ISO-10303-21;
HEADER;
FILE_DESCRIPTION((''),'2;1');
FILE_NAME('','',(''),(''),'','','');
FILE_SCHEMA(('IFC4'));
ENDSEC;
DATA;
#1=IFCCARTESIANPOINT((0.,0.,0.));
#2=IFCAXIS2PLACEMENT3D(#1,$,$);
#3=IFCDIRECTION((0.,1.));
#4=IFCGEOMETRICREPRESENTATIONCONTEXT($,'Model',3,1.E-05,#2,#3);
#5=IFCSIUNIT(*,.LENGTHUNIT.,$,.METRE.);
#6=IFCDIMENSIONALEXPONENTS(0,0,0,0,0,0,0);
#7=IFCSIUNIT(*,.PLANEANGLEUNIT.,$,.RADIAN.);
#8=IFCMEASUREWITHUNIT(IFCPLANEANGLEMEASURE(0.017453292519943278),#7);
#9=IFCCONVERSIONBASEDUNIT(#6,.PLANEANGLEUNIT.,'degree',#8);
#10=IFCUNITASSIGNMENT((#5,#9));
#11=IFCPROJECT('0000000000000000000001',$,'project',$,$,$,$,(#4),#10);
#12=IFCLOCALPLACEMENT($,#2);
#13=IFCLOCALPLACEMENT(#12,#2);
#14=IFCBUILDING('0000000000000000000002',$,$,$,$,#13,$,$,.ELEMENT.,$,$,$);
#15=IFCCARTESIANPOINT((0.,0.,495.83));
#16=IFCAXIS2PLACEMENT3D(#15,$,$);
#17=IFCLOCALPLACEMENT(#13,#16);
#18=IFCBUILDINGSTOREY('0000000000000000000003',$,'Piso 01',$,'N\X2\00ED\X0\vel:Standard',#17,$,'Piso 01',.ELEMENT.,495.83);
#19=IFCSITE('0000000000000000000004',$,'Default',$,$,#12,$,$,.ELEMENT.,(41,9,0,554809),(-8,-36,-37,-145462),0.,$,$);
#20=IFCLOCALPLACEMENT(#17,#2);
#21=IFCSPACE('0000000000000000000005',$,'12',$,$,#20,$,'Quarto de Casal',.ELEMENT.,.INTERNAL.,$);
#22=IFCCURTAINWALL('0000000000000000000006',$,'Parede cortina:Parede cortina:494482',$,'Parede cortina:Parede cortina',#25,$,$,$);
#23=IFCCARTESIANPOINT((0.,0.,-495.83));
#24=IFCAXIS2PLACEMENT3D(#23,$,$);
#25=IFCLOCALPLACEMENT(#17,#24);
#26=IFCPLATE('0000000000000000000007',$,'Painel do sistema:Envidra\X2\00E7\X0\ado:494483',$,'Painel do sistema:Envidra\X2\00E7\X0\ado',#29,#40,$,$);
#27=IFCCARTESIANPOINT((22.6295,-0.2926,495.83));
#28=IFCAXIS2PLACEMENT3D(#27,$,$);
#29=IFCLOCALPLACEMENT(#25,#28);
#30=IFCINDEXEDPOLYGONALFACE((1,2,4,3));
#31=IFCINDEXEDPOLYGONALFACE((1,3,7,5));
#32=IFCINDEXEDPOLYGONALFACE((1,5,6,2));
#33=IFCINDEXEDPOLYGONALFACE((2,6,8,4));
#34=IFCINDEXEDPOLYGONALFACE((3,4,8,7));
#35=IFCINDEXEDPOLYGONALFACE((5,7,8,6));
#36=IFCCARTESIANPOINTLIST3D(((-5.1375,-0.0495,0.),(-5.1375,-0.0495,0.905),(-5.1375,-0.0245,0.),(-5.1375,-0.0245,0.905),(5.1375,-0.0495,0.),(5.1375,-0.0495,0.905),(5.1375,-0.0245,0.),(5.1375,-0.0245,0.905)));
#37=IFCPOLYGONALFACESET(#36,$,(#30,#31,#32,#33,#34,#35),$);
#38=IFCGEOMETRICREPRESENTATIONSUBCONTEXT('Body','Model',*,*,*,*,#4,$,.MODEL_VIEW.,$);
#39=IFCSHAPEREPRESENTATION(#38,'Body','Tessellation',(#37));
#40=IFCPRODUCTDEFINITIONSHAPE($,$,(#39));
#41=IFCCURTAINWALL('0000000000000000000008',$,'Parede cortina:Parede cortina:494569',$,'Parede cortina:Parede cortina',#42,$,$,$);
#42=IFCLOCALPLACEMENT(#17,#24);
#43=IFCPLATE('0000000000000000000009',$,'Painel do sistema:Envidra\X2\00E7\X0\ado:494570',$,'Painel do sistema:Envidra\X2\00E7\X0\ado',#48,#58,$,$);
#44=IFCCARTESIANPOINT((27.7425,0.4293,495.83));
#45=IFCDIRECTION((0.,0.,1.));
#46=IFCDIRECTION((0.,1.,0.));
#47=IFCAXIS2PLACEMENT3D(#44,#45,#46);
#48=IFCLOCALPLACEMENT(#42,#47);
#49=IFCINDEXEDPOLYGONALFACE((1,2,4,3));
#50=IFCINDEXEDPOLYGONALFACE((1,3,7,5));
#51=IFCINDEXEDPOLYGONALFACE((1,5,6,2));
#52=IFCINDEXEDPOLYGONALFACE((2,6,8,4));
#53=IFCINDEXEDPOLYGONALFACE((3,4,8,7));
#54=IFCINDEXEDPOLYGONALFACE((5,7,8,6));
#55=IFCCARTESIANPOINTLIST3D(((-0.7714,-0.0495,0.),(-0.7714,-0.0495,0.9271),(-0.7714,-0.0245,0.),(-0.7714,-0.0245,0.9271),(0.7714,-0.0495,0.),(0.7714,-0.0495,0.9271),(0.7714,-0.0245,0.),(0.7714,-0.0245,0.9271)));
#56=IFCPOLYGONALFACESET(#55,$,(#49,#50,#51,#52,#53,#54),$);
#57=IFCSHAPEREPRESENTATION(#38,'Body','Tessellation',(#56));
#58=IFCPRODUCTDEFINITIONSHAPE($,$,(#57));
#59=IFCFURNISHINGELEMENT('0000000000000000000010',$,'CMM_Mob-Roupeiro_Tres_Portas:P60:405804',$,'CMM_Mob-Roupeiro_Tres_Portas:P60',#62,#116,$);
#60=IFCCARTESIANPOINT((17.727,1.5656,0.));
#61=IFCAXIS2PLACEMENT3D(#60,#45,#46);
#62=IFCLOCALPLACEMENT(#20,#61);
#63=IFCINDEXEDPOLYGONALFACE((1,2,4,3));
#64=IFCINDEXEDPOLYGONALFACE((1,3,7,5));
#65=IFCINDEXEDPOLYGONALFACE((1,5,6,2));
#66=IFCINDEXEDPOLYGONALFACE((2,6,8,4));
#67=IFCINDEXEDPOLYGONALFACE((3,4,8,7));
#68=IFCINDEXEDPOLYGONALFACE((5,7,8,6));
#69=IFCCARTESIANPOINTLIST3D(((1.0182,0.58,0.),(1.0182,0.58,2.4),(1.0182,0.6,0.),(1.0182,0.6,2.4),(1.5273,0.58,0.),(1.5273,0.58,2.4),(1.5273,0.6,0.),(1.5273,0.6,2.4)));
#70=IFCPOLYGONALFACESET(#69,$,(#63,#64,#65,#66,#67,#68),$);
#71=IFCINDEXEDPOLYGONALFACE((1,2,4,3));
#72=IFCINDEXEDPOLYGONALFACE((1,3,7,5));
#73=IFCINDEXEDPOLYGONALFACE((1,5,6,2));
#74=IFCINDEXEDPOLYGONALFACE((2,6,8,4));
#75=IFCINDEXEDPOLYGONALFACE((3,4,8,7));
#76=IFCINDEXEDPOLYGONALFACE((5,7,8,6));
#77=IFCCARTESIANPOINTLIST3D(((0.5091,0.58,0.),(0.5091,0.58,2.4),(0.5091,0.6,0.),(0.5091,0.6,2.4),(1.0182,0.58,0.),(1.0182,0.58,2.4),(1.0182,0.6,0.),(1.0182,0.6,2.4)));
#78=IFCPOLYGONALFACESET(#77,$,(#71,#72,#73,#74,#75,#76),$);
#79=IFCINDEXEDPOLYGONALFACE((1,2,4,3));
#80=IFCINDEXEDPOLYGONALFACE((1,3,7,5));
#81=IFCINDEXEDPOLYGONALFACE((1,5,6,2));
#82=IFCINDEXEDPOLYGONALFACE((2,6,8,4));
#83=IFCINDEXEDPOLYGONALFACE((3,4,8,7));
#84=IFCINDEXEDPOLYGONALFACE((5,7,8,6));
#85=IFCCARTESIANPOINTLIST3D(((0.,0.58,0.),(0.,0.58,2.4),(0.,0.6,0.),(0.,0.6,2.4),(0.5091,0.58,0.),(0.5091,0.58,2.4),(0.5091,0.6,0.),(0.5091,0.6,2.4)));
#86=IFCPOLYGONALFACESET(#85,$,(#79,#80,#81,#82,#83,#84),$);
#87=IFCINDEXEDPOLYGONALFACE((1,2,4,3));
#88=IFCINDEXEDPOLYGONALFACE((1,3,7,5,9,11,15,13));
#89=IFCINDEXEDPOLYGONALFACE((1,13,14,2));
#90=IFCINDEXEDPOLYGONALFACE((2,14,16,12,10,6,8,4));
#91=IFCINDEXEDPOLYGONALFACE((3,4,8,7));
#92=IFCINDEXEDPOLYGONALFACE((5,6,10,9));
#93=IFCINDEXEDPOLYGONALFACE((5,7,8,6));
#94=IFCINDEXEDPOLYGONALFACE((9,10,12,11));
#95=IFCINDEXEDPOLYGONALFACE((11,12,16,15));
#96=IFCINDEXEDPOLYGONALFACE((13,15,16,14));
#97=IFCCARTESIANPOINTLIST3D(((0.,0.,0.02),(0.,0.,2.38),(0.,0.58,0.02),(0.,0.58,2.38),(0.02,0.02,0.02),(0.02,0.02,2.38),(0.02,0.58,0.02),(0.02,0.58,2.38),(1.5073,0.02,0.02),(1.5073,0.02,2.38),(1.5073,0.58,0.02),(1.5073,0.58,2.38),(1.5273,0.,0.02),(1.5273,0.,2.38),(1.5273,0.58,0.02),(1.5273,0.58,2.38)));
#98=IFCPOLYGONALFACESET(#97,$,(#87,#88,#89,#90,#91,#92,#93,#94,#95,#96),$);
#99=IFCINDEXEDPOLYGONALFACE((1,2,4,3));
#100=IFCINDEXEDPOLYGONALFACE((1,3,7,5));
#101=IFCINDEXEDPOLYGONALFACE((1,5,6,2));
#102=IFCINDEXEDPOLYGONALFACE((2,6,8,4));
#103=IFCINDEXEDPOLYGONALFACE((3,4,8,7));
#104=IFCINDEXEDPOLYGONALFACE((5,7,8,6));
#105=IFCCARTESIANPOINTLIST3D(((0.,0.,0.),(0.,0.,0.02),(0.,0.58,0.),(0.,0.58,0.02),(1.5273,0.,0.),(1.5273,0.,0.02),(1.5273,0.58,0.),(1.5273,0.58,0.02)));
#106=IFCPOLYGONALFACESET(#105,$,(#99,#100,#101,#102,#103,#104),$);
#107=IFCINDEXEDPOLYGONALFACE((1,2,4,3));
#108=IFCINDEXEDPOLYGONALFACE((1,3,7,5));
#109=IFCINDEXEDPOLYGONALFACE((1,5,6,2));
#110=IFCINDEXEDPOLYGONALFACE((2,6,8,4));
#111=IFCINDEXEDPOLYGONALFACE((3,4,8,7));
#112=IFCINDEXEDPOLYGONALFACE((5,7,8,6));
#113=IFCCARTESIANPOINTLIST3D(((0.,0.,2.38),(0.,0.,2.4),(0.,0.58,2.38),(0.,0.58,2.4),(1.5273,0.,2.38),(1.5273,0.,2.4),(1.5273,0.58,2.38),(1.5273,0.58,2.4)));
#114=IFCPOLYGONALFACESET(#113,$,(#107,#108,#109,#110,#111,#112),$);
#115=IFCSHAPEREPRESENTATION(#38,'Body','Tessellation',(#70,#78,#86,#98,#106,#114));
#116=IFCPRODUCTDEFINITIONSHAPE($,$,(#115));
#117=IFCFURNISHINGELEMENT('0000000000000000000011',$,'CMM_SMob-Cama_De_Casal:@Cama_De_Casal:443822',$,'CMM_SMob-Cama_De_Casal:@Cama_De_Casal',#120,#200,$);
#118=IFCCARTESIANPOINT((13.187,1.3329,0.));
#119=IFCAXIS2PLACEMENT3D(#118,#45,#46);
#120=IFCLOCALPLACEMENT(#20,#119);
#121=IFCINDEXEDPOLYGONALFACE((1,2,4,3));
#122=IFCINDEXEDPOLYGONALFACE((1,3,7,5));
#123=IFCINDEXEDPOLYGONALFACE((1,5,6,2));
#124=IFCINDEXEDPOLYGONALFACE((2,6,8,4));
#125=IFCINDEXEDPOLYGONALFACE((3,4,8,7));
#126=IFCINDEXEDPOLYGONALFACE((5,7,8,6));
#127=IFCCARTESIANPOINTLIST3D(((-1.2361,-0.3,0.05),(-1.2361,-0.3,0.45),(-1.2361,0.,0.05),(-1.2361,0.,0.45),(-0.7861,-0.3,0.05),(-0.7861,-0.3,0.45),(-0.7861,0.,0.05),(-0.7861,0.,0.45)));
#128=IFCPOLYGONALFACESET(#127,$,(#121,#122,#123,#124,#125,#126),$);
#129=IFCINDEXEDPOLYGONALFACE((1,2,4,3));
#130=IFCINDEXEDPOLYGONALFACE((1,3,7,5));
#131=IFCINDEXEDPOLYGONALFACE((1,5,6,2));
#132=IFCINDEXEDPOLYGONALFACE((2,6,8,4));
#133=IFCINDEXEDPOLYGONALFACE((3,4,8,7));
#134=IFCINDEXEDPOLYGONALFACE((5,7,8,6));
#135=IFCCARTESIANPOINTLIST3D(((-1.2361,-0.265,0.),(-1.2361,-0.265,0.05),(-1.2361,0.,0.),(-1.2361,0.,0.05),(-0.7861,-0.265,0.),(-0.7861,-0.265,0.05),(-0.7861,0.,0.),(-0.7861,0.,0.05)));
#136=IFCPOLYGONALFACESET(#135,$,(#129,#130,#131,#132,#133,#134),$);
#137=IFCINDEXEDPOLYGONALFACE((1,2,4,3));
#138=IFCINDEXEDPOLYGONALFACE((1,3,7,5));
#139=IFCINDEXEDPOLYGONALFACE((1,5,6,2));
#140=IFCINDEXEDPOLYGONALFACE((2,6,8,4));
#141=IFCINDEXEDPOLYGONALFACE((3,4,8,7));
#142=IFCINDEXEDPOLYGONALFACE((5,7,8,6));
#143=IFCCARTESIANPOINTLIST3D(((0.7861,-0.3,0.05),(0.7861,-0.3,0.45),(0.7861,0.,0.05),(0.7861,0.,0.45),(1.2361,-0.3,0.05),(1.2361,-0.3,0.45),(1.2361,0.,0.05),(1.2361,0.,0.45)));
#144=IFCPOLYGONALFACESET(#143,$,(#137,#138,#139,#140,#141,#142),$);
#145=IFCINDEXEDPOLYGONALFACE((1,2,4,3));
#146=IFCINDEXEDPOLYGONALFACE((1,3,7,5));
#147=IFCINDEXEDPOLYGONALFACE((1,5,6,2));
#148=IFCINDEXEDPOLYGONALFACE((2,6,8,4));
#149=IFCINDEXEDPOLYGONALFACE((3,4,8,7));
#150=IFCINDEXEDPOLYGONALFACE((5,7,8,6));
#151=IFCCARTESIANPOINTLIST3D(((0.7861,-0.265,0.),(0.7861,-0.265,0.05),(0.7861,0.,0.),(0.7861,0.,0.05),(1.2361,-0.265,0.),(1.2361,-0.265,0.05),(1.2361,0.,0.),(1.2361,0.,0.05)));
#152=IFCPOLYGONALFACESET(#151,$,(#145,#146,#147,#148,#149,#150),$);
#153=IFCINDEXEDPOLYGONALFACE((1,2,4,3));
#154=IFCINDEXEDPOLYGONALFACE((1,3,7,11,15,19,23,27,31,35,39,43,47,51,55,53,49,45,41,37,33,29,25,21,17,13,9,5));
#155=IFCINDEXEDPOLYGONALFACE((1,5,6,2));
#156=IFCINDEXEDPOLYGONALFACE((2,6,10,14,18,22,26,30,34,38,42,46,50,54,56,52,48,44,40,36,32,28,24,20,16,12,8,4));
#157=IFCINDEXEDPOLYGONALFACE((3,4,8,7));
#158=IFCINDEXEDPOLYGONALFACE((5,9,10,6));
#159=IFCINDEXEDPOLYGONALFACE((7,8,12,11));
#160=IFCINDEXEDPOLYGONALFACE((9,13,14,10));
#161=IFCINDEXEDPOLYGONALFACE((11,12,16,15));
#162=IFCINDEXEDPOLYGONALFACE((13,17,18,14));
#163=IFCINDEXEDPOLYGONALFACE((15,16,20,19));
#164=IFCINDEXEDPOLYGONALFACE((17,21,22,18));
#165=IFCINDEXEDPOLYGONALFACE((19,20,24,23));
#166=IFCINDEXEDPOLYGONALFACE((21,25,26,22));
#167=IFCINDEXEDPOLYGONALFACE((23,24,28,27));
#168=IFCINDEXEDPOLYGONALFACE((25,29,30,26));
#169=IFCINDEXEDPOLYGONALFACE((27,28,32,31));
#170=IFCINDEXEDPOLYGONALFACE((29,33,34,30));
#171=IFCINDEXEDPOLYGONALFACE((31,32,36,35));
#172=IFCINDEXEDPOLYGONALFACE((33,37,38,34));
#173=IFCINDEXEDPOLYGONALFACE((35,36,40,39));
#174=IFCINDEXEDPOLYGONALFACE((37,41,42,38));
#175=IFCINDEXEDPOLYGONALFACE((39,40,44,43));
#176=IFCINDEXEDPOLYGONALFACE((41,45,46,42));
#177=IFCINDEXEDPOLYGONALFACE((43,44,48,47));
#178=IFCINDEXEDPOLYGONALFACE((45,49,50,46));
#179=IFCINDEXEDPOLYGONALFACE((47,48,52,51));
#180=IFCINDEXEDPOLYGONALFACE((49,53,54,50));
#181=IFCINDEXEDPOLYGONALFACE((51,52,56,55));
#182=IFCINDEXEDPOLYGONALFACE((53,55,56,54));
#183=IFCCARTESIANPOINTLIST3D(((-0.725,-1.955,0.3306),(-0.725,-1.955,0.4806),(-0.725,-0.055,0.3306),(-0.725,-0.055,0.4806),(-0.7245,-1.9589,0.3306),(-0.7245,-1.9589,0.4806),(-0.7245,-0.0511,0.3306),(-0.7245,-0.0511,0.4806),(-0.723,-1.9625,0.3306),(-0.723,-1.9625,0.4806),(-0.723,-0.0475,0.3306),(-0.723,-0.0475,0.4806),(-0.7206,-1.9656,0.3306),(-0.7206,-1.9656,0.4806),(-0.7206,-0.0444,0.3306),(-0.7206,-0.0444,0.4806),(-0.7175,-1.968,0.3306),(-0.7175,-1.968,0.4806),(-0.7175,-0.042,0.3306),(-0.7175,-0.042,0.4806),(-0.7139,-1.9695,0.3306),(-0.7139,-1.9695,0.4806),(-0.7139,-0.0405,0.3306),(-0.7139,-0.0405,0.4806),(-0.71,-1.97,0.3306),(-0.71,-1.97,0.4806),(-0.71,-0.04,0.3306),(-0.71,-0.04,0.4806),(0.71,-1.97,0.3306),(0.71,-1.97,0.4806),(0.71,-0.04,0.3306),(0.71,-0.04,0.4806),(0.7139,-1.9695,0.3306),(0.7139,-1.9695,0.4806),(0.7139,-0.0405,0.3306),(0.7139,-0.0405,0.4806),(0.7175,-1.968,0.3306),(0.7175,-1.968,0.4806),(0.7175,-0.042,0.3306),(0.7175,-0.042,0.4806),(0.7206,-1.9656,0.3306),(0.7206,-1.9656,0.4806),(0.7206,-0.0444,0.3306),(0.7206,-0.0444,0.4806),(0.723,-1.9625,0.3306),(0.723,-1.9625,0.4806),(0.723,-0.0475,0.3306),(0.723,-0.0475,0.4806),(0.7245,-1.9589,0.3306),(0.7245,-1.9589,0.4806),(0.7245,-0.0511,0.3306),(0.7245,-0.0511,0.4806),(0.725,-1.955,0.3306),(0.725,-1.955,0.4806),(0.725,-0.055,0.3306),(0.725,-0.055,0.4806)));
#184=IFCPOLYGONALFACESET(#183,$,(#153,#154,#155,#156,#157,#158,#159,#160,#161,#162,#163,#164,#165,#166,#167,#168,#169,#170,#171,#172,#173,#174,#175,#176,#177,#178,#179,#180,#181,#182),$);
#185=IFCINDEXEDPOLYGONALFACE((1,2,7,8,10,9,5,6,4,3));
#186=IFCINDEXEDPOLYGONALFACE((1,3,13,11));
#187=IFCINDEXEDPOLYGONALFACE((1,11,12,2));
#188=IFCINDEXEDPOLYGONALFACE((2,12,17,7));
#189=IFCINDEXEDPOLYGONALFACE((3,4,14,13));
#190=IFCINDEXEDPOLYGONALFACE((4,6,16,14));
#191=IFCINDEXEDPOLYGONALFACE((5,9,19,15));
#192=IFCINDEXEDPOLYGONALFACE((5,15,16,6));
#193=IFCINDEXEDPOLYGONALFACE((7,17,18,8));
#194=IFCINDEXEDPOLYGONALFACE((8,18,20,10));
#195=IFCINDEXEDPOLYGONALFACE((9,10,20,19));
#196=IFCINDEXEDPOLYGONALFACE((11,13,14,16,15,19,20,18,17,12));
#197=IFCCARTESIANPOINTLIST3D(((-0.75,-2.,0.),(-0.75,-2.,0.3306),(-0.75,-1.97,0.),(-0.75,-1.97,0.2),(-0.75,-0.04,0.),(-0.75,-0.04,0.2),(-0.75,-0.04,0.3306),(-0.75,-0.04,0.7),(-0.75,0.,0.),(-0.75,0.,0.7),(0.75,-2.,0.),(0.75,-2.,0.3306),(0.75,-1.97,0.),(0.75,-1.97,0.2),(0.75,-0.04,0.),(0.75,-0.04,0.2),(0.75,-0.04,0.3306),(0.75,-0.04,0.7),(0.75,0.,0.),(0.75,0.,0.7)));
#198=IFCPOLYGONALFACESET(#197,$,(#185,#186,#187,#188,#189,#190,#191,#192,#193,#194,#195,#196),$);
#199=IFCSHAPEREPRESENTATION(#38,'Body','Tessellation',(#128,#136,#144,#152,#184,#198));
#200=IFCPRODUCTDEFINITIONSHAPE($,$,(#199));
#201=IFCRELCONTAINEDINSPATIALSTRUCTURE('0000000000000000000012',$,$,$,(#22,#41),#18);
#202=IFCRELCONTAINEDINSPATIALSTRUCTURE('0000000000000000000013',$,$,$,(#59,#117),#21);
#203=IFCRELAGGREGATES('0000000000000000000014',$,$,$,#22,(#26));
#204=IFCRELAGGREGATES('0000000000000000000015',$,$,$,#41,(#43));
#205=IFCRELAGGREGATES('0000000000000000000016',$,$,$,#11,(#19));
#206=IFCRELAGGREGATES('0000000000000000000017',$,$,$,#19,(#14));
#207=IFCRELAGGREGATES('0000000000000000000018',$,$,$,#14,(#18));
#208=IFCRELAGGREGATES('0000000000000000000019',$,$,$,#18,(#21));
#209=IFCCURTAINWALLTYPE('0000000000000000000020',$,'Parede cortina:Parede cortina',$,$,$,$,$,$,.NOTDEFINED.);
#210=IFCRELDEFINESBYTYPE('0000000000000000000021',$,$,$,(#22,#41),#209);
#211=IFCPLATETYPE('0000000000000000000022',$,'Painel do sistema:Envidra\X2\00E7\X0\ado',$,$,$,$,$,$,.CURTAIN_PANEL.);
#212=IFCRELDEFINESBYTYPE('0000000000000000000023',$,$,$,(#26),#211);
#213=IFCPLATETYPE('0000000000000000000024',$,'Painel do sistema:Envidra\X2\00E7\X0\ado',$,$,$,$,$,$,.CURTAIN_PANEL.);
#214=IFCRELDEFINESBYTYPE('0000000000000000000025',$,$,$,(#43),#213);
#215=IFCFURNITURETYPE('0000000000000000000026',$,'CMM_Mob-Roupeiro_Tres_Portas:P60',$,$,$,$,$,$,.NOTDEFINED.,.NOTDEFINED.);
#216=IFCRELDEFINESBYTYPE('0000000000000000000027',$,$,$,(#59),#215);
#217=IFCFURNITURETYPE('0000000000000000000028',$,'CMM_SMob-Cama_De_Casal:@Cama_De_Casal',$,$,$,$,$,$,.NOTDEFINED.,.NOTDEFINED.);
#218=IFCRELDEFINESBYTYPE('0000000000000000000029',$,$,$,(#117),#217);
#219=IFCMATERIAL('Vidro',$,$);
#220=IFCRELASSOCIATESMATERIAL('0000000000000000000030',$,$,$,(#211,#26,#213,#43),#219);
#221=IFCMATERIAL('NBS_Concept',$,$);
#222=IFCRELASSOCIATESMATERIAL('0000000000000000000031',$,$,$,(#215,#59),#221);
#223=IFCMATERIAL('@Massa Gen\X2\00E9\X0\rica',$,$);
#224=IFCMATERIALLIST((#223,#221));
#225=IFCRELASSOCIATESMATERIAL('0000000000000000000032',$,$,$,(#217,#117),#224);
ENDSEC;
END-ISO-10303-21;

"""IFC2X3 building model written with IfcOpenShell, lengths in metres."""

from ifc_helpers import new_model, entity, si_unit, converted_unit, direction, frame, frame_2d, origin, origin_2d_with_axis, place, context, subcontext, project, spatial, polyline, circle_curve, parameter, trimmed, segment, composite_curve, rectangle, outline, extrude, source, transform, mapped, material, material_list, type_object, type_shapes, element, aggregate, save


model = new_model("IFC2X3")

# Units and contexts
model_context = context("Model", 3, precision=1e-05, world=origin(), true_north=direction((0.0, 1.0)))
body_context = subcontext(model_context, "Body", "Model", "MODEL_VIEW")
ifc_project = project(units=[si_unit("LENGTHUNIT", "METRE"), converted_unit("PLANEANGLEUNIT", "degree", entity("IfcPlaneAngleMeasure", 0.017453292519943278), si_unit("PLANEANGLEUNIT", "RADIAN"), dimensions=[0, 0, 0, 0, 0, 0, 0])], contexts=[model_context])

# Site, building, storey
site_placement = place(None, origin())
site = spatial("IfcSite", under=ifc_project, at=site_placement, Name="Default", CompositionType="ELEMENT", RefLatitude=(41, 9, 0, 554809), RefLongitude=(-8, -36, -37, -145462), RefElevation=0.0)
building_placement = place(site_placement, origin())
building = spatial("IfcBuilding", under=site, at=building_placement, CompositionType="ELEMENT")
storey_placement = place(building_placement, frame((0.0, 0.0, 495.83)))
storey = spatial("IfcBuildingStorey", under=building, at=storey_placement, Name="Piso 01", ObjectType="Nível:Standard", LongName="Piso 01", CompositionType="ELEMENT", Elevation=495.83)

# Curtain walls, plates
curtain_wall_type = type_object("IfcCurtainWallType", Name="Parede cortina:Parede cortina", PredefinedType="NOTDEFINED")
curtain_wall_1_placement = place(storey_placement, frame((0.0, 0.0, -495.83)))
curtain_wall_1 = element("IfcCurtainWall", 1, at=curtain_wall_1_placement, inside=storey, type_object=curtain_wall_type, Name="Parede cortina:Parede cortina:494482", ObjectType="Parede cortina:Parede cortina")
ifc_material_1 = material(Name="Vidro")
plate_type_1 = type_object("IfcPlateType", Name="Painel do sistema:Envidraçado", PredefinedType="CURTAIN_PANEL", material=ifc_material_1)
shared_shape_1 = source(origin(), body_context, "Body", "SweptSolid", [
    extrude(rectangle(XDim=0.025, YDim=10.275, at=frame_2d((0.0, 0.0), x_axis=(1.0, 0.0))), frame((0.0, -0.037, 0.0), z_axis=(0.0, 0.0, 1.0), x_axis=(0.0, 1.0, 0.0)), (0.0, 0.0, 1.0), 0.905),
])
type_shapes(plate_type_1, [shared_shape_1])
plate_1_placement = place(curtain_wall_1_placement, frame((22.6295, -0.2926, 495.83)))
plate_1 = element("IfcPlate", 2, at=plate_1_placement, type_object=plate_type_1, material=ifc_material_1, Name="Painel do sistema:Envidraçado:494483", ObjectType="Painel do sistema:Envidraçado", context=body_context, shape_type="MappedRepresentation", body=[
    mapped(shared_shape_1, transform((0.0, 0.0, 0.0), scale=1.0)),
])
aggregate(curtain_wall_1, [plate_1])
curtain_wall_2_placement = place(storey_placement, frame((0.0, 0.0, -495.83)))
curtain_wall_2 = element("IfcCurtainWall", 3, at=curtain_wall_2_placement, inside=storey, type_object=curtain_wall_type, Name="Parede cortina:Parede cortina:494569", ObjectType="Parede cortina:Parede cortina")
plate_type_2 = type_object("IfcPlateType", Name="Painel do sistema:Envidraçado", PredefinedType="CURTAIN_PANEL", material=ifc_material_1)
shared_shape_2 = source(origin(), body_context, "Body", "SweptSolid", [
    extrude(rectangle(XDim=0.025, YDim=1.5427, at=frame_2d((0.0, 0.0), x_axis=(1.0, 0.0))), frame((0.0, -0.037, 0.0), z_axis=(0.0, 0.0, 1.0), x_axis=(0.0, 1.0, 0.0)), (0.0, 0.0, 1.0), 0.9271),
])
type_shapes(plate_type_2, [shared_shape_2])
plate_2_placement = place(curtain_wall_2_placement, frame((27.7425, 0.4293, 495.83), z_axis=(0.0, 0.0, 1.0), x_axis=(0.0, 1.0, 0.0)))
plate_2 = element("IfcPlate", 4, at=plate_2_placement, type_object=plate_type_2, material=ifc_material_1, Name="Painel do sistema:Envidraçado:494570", ObjectType="Painel do sistema:Envidraçado", context=body_context, shape_type="MappedRepresentation", body=[
    mapped(shared_shape_2, transform((0.0, 0.0, 0.0), scale=1.0)),
])
aggregate(curtain_wall_2, [plate_2])

# Shared definitions
space_1_placement = place(storey_placement, origin())
space_1 = spatial("IfcSpace", under=storey, at=space_1_placement, Name="12", LongName="Quarto de Casal", CompositionType="ELEMENT", InteriorOrExteriorSpace="INTERNAL")

# Furnishing element
ifc_material_2 = material(Name="NBS_Concept")
furniture_type_1 = type_object("IfcFurnitureType", Name="CMM_Mob-Roupeiro_Tres_Portas:P60", AssemblyPlace="NOTDEFINED", material=ifc_material_2)
shared_shape_3 = source(origin(), body_context, "Body", "SweptSolid", [
    extrude(rectangle(XDim=0.5091, YDim=0.02, at=frame_2d((0.0, 0.0), x_axis=(1.0, 0.0))), frame((1.2727, 0.59, 0.0), z_axis=(0.0, 0.0, 1.0), x_axis=(-1.0, 0.0, 0.0)), (0.0, 0.0, 1.0), 2.4),
    extrude(rectangle(XDim=0.5091, YDim=0.02, at=frame_2d((0.0, 0.0), x_axis=(1.0, 0.0))), frame((0.7636, 0.59, 0.0), z_axis=(0.0, 0.0, 1.0), x_axis=(-1.0, 0.0, 0.0)), (0.0, 0.0, 1.0), 2.4),
    extrude(rectangle(XDim=0.5091, YDim=0.02, at=frame_2d((0.0, 0.0), x_axis=(1.0, 0.0))), frame((0.2545, 0.59, 0.0), z_axis=(0.0, 0.0, 1.0), x_axis=(-1.0, 0.0, 0.0)), (0.0, 0.0, 1.0), 2.4),
    extrude(outline(polyline([(-0.7636, -0.295), (0.7636, -0.295), (0.7636, 0.285), (0.7436, 0.285), (0.7436, -0.275), (-0.7436, -0.275), (-0.7436, 0.285), (-0.7636, 0.285), (-0.7636, -0.295)])), frame((0.7636, 0.295, 0.02)), (0.0, 0.0, 1.0), 2.36),
    extrude(rectangle(XDim=1.5273, YDim=0.58, at=frame_2d((0.0, 0.0), x_axis=(1.0, 0.0))), frame((0.7636, 0.29, 0.0), z_axis=(0.0, 0.0, 1.0), x_axis=(-1.0, 0.0, 0.0)), (0.0, 0.0, 1.0), 0.02),
    extrude(rectangle(XDim=1.5273, YDim=0.58, at=frame_2d((0.0, 0.0), x_axis=(1.0, 0.0))), frame((0.7636, 0.29, 2.38), z_axis=(0.0, 0.0, 1.0), x_axis=(-1.0, 0.0, 0.0)), (0.0, 0.0, 1.0), 0.02),
])
type_shapes(furniture_type_1, [shared_shape_3])
furnishing_1_placement = place(space_1_placement, frame((17.727, 1.5656, 0.0), z_axis=(0.0, 0.0, 1.0), x_axis=(0.0, 1.0, 0.0)))
element("IfcFurnishingElement", 5, at=furnishing_1_placement, inside=space_1, type_object=furniture_type_1, material=ifc_material_2, Name="CMM_Mob-Roupeiro_Tres_Portas:P60:405804", ObjectType="CMM_Mob-Roupeiro_Tres_Portas:P60", context=body_context, shape_type="MappedRepresentation", body=[
    mapped(shared_shape_3, transform((0.0, 0.0, 0.0), scale=1.0)),
])

# Furnishing element
ifc_material_3 = material(Name="@Massa Genérica")
ifc_material_list = material_list([ifc_material_3, ifc_material_2])
furniture_type_2 = type_object("IfcFurnitureType", Name="CMM_SMob-Cama_De_Casal:@Cama_De_Casal", AssemblyPlace="NOTDEFINED", material=ifc_material_list)
shared_shape_4 = source(origin(), body_context, "Body", "SweptSolid", [
    extrude(rectangle(XDim=0.3, YDim=0.45, at=frame_2d((0.0, 0.0), x_axis=(1.0, 0.0))), frame((-1.0111, -0.15, 0.05), z_axis=(0.0, 0.0, 1.0), x_axis=(0.0, 1.0, 0.0)), (0.0, 0.0, 1.0), 0.4),
    extrude(rectangle(XDim=0.265, YDim=0.45, at=frame_2d((0.0, 0.0), x_axis=(1.0, 0.0))), frame((-1.0111, -0.1325, 0.0), z_axis=(0.0, 0.0, 1.0), x_axis=(0.0, -1.0, 0.0)), (0.0, 0.0, 1.0), 0.05),
    extrude(rectangle(XDim=0.45, YDim=0.3, at=origin_2d_with_axis()), frame((1.0111, -0.15, 0.05)), (0.0, 0.0, 1.0), 0.4),
    extrude(rectangle(XDim=0.45, YDim=0.265, at=origin_2d_with_axis()), frame((1.0111, -0.1325, 0.0), z_axis=(0.0, 0.0, 1.0), x_axis=(-1.0, 0.0, 0.0)), (0.0, 0.0, 1.0), 0.05),
    extrude(outline(composite_curve([segment(polyline([(-0.71, -0.965), (0.71, -0.965)]), True, "CONTINUOUS"), segment(trimmed(circle_curve(frame_2d((0.71, -0.95), x_axis=(-1.0, 0.0)), 0.015), [parameter(90.0)], [parameter(180.0)], True, "PARAMETER"), True, "CONTINUOUS"), segment(polyline([(0.725, -0.95), (0.725, 0.95)]), True, "CONTINUOUS"), segment(trimmed(circle_curve(frame_2d((0.71, 0.95), x_axis=(-1.0, 0.0)), 0.015), [parameter(180.0)], [parameter(270.0)], True, "PARAMETER"), True, "CONTINUOUS"), segment(polyline([(0.71, 0.965), (-0.71, 0.965)]), True, "CONTINUOUS"), segment(trimmed(circle_curve(frame_2d((-0.71, 0.95), x_axis=(-1.0, 0.0)), 0.015), [parameter(270.0)], [parameter(0.0)], True, "PARAMETER"), True, "CONTINUOUS"), segment(polyline([(-0.725, 0.95), (-0.725, -0.95)]), True, "CONTINUOUS"), segment(trimmed(circle_curve(frame_2d((-0.71, -0.95), x_axis=(-1.0, 0.0)), 0.015), [parameter(0.0)], [parameter(90.0)], True, "PARAMETER"), True, "CONTINUOUS")], self_intersect=False)), frame((0.0, -1.005, 0.3306), z_axis=(0.0, 0.0, 1.0), x_axis=(-1.0, 0.0, 0.0)), (0.0, 0.0, 1.0), 0.15),
    extrude(outline(polyline([(-0.2461, -1.16), (-0.2461, -1.19), (0.0845, -1.19), (0.0845, 0.77), (0.4539, 0.77), (0.4539, 0.81), (-0.2461, 0.81), (-0.2461, 0.77), (-0.0461, 0.77), (-0.0461, -1.16), (-0.2461, -1.16)])), frame((-0.75, -0.81, 0.2461), z_axis=(-1.0, 0.0, 0.0), x_axis=(0.0, 0.0, 1.0)), (0.0, 0.0, -1.0), 1.5),
])
type_shapes(furniture_type_2, [shared_shape_4])
furnishing_2_placement = place(space_1_placement, frame((13.187, 1.3329, 0.0), z_axis=(0.0, 0.0, 1.0), x_axis=(0.0, 1.0, 0.0)))
element("IfcFurnishingElement", 6, at=furnishing_2_placement, inside=space_1, type_object=furniture_type_2, material=ifc_material_list, Name="CMM_SMob-Cama_De_Casal:@Cama_De_Casal:443822", ObjectType="CMM_SMob-Cama_De_Casal:@Cama_De_Casal", context=body_context, shape_type="MappedRepresentation", body=[
    mapped(shared_shape_4, transform((0.0, 0.0, 0.0), scale=1.0)),
])

save(model, "model.ifc")
